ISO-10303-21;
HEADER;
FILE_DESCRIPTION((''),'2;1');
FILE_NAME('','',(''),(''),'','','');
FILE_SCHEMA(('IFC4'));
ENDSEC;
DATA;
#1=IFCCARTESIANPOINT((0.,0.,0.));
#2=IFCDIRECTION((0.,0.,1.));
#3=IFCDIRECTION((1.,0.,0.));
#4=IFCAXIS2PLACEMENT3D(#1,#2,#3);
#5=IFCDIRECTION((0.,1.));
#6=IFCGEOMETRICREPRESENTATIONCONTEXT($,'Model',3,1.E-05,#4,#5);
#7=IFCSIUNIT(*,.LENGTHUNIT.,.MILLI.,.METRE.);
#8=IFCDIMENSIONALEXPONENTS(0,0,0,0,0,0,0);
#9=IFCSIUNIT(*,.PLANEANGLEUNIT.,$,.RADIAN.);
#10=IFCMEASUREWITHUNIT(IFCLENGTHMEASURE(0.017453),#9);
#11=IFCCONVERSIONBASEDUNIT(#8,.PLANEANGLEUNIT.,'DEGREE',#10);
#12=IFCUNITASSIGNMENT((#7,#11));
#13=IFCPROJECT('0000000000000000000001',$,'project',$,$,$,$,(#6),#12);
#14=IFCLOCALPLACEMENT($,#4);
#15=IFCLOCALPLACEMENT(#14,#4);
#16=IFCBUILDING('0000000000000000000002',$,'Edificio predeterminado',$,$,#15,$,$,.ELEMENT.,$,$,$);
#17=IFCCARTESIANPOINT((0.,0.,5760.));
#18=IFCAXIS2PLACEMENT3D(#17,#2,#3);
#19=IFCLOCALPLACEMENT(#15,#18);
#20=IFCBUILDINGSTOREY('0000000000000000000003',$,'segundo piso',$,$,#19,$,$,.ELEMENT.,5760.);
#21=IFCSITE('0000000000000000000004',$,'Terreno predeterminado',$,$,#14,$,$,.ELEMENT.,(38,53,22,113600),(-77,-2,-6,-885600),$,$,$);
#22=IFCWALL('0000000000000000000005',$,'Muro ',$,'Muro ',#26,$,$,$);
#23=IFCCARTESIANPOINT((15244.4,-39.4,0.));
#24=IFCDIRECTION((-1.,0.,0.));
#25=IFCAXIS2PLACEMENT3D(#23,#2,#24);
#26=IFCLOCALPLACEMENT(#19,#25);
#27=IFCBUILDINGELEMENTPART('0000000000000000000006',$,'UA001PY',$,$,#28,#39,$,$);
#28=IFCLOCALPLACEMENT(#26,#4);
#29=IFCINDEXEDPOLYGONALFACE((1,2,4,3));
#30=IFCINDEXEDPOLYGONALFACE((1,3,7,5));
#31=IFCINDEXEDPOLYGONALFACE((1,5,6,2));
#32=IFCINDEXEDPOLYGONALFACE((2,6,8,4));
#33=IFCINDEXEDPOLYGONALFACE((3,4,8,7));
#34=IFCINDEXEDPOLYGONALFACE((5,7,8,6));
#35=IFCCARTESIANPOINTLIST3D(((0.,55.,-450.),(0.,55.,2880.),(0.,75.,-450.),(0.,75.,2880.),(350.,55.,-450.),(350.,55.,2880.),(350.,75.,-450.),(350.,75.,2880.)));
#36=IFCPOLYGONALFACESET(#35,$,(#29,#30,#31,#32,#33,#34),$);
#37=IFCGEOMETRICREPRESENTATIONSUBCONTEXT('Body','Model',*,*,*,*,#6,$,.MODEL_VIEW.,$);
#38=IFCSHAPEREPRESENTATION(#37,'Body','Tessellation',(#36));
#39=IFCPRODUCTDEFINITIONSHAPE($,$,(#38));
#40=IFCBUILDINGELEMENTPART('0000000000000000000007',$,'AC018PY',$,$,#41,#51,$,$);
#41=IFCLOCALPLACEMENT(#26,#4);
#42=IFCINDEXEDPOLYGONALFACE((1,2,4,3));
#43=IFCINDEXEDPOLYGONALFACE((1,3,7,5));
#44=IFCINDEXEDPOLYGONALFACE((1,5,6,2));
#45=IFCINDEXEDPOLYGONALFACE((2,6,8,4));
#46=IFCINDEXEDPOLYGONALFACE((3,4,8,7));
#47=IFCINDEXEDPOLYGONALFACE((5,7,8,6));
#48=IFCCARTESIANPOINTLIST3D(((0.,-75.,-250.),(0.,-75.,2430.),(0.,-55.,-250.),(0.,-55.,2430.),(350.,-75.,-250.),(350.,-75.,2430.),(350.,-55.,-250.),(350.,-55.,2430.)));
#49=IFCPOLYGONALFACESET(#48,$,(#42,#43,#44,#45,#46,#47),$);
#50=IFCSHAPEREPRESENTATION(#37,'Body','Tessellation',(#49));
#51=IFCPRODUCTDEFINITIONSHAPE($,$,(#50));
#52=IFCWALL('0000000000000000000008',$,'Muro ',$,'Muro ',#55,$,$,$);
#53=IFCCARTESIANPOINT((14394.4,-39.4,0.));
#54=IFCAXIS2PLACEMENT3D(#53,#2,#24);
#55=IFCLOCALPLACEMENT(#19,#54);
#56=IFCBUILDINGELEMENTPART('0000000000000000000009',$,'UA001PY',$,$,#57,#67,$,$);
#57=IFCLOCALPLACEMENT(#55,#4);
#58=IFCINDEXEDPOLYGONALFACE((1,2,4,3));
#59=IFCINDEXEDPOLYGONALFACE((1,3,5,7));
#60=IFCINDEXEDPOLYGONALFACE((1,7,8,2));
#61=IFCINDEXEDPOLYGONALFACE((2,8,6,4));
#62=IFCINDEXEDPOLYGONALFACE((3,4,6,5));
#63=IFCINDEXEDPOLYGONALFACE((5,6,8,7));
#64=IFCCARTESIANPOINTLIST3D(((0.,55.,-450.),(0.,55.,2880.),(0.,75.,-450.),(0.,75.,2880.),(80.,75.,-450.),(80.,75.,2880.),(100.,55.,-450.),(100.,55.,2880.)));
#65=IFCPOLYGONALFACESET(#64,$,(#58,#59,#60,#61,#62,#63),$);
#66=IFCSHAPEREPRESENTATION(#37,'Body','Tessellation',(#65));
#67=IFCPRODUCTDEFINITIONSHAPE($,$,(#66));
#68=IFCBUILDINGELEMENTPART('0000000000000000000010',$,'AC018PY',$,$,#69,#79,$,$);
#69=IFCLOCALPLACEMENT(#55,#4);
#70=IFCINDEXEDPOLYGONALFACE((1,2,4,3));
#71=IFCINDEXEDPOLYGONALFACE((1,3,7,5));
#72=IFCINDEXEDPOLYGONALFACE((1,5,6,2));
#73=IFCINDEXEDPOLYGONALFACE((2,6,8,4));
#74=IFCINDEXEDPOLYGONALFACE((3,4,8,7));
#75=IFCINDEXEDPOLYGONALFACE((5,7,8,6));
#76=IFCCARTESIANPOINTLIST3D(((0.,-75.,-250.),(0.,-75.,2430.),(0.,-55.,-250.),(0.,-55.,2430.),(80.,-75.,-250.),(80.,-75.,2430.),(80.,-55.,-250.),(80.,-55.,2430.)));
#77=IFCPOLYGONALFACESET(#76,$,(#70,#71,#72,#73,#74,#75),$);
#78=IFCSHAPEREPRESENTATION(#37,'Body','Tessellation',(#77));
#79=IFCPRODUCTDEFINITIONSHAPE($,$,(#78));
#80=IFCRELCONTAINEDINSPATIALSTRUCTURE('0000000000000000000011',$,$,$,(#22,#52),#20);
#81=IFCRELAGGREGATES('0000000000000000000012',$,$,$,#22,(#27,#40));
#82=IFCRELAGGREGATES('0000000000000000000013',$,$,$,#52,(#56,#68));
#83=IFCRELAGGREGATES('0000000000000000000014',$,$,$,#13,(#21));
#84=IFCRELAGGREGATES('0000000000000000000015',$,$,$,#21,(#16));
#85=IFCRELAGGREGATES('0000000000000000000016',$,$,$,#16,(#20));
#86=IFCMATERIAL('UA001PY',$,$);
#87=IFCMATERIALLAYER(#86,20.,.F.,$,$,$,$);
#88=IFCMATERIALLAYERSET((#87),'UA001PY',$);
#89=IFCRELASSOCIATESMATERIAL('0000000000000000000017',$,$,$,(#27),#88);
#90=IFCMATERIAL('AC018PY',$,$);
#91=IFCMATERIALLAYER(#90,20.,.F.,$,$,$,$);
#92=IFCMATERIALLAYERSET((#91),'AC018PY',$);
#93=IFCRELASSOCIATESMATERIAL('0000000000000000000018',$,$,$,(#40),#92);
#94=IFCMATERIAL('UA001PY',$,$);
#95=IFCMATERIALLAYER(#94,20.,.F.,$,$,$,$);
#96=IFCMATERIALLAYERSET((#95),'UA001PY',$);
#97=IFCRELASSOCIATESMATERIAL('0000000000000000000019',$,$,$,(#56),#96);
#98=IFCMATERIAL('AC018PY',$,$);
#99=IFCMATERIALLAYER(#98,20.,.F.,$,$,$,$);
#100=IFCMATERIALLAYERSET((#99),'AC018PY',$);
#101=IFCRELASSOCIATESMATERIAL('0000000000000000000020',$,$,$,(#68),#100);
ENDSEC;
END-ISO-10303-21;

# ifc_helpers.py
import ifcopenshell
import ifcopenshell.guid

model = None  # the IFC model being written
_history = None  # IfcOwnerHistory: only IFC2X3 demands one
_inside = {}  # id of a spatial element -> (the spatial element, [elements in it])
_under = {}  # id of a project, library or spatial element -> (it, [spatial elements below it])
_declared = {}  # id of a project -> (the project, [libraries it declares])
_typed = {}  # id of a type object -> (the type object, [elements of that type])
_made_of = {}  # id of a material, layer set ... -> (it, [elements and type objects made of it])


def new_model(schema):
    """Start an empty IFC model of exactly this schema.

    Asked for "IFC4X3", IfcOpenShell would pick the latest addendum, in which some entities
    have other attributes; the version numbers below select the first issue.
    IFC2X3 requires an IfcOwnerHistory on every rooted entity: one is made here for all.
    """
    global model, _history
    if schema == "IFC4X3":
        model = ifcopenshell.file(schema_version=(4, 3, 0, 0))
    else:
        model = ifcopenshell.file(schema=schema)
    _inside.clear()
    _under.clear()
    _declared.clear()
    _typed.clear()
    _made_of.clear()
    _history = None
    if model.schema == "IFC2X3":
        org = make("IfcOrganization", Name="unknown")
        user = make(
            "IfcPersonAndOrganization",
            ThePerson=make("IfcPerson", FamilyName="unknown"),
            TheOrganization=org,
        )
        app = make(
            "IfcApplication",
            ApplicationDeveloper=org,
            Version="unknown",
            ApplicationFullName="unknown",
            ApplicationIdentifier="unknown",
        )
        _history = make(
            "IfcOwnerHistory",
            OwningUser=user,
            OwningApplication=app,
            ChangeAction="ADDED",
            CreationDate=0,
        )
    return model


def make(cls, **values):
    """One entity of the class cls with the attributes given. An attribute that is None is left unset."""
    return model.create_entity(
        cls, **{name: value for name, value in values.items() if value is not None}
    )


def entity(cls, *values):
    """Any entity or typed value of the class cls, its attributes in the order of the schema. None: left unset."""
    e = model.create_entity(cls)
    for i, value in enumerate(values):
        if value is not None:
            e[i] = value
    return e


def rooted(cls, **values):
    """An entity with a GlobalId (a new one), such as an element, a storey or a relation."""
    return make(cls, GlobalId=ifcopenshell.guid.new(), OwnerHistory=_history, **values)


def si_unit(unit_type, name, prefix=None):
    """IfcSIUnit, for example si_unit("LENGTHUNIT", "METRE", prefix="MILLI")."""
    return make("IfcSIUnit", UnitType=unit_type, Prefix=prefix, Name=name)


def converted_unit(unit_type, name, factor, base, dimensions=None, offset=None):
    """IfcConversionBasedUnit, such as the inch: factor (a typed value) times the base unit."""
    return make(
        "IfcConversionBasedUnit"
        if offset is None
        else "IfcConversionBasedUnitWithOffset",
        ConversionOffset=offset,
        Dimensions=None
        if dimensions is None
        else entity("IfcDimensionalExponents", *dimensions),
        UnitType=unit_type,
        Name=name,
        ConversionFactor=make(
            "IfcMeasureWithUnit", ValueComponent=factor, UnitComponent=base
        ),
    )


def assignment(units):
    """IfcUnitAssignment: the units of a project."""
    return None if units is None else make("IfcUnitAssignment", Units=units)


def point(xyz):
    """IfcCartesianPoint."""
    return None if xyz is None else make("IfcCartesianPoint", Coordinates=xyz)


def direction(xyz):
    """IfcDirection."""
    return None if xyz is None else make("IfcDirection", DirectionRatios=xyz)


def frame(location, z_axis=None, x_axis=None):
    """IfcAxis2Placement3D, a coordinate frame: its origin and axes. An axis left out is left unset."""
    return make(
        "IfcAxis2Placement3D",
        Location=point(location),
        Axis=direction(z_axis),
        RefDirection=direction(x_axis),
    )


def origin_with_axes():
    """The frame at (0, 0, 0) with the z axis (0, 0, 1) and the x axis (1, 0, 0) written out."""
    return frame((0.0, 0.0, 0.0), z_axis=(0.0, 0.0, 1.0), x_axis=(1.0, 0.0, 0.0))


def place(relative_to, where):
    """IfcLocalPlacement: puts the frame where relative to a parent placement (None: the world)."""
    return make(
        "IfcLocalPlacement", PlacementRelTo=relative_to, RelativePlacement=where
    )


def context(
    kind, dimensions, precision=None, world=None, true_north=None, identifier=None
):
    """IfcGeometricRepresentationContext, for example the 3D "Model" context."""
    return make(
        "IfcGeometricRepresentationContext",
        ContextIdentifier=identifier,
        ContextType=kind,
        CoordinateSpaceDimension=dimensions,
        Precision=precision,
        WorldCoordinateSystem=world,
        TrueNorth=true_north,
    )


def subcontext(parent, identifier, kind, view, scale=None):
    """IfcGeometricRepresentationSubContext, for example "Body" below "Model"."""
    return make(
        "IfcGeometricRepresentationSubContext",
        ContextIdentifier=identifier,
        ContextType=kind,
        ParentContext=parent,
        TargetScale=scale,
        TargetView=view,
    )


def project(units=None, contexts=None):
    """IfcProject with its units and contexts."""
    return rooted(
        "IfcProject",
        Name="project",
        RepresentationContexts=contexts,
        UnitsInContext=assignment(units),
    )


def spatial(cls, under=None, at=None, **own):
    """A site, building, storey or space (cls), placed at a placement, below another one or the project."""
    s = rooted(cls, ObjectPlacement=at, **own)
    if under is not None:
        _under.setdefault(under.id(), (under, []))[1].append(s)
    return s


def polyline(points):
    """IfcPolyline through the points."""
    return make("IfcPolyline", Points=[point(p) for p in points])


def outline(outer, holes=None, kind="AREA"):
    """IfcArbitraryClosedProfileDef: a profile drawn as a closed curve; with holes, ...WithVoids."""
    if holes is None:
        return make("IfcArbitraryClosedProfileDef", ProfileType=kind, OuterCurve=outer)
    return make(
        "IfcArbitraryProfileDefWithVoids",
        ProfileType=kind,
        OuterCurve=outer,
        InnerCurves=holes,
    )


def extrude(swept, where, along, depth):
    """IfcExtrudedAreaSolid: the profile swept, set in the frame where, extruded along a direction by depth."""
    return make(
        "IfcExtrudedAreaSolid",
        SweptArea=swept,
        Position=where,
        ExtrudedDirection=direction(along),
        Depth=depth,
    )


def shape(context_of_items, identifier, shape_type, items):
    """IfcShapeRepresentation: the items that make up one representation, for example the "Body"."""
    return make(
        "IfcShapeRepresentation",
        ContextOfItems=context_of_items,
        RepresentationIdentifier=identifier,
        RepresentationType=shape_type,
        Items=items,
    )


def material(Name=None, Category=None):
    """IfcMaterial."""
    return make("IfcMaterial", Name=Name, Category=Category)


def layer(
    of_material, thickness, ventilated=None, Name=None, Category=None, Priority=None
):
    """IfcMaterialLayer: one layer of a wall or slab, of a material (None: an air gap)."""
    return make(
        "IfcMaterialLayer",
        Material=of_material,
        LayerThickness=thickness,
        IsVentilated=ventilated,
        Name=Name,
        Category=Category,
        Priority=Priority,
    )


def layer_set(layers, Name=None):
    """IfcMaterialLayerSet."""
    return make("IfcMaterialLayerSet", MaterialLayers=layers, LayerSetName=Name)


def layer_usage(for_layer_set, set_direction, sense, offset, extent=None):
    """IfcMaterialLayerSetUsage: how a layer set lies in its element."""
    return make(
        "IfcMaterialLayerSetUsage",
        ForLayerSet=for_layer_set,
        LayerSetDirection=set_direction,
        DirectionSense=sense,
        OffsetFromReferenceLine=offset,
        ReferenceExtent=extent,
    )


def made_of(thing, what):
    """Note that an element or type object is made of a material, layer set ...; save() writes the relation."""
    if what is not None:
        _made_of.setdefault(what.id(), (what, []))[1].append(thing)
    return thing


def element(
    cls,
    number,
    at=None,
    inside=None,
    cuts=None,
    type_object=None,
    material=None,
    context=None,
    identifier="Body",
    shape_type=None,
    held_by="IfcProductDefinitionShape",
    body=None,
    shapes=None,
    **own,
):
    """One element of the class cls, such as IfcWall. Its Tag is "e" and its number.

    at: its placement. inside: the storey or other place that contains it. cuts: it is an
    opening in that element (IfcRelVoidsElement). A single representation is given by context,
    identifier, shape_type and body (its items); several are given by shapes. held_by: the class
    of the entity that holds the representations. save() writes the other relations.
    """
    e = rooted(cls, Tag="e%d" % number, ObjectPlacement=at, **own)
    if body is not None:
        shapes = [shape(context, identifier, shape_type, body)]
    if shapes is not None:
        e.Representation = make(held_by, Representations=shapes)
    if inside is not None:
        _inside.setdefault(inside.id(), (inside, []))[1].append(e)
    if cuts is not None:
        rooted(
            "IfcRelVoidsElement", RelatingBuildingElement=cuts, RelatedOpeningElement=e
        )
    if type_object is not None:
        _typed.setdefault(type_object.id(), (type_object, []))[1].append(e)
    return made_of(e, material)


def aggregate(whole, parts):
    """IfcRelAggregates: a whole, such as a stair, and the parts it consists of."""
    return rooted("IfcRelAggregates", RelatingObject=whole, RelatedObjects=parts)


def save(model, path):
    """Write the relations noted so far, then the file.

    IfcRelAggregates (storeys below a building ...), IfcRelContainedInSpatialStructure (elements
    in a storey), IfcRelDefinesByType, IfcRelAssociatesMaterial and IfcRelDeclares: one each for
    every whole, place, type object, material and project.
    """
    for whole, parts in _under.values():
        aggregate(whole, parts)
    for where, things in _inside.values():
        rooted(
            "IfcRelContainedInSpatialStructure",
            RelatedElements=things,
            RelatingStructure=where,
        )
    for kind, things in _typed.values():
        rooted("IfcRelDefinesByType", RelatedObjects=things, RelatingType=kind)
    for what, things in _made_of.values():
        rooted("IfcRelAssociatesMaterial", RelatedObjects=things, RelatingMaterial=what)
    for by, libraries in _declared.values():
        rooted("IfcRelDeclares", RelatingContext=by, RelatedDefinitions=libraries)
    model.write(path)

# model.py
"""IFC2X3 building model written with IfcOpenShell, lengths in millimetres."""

from ifc_helpers import new_model, entity, si_unit, converted_unit, direction, frame, origin_with_axes, place, context, subcontext, project, spatial, polyline, outline, extrude, material, layer, layer_set, layer_usage, element, aggregate, save


model = new_model("IFC2X3")

# Units and contexts
model_context = context("Model", 3, precision=1e-05, world=origin_with_axes(), true_north=direction((0.0, 1.0)))
body_context = subcontext(model_context, "Body", "Model", "MODEL_VIEW")
ifc_project = project(units=[si_unit("LENGTHUNIT", "METRE", prefix="MILLI"), converted_unit("PLANEANGLEUNIT", "DEGREE", entity("IfcLengthMeasure", 0.017453), si_unit("PLANEANGLEUNIT", "RADIAN"), dimensions=[0, 0, 0, 0, 0, 0, 0])], contexts=[model_context])

# Site, building, storey
site_placement = place(None, origin_with_axes())
site = spatial("IfcSite", under=ifc_project, at=site_placement, Name="Terreno predeterminado", CompositionType="ELEMENT", RefLatitude=(38, 53, 22, 113600), RefLongitude=(-77, -2, -6, -885600))
building_placement = place(site_placement, origin_with_axes())
building = spatial("IfcBuilding", under=site, at=building_placement, Name="Edificio predeterminado", CompositionType="ELEMENT")
storey_placement = place(building_placement, frame((0.0, 0.0, 5760.0), z_axis=(0.0, 0.0, 1.0), x_axis=(1.0, 0.0, 0.0)))
storey = spatial("IfcBuildingStorey", under=building, at=storey_placement, Name="segundo piso", CompositionType="ELEMENT", Elevation=5760.0)

# Walls, building element parts
wall_1_placement = place(storey_placement, frame((15244.4, -39.4, 0.0), z_axis=(0.0, 0.0, 1.0), x_axis=(-1.0, 0.0, 0.0)))
wall_1 = element("IfcWall", 1, at=wall_1_placement, inside=storey, Name="Muro ", ObjectType="Muro ")
ifc_material_1 = material(Name="UA001PY")
ifc_layer_1 = layer(ifc_material_1, 20.0, ventilated=False)
ifc_layer_set_1 = layer_set([ifc_layer_1], Name="UA001PY")
ifc_layer_usage_1 = layer_usage(ifc_layer_set_1, "AXIS2", "NEGATIVE", -75.0)
building_element_part_1_placement = place(wall_1_placement, origin_with_axes())
building_element_part_1 = element("IfcBuildingElementPart", 2, at=building_element_part_1_placement, material=ifc_layer_usage_1, Name="UA001PY", context=body_context, shape_type="SweptSolid", body=[
    extrude(outline(polyline([(350.0, 75.0), (350.0, 55.0), (0.0, 55.0), (0.0, 75.0), (350.0, 75.0)])), frame((0.0, 0.0, -450.0), z_axis=(0.0, 0.0, 1.0), x_axis=(1.0, 0.0, 0.0)), (0.0, 0.0, 1.0), 3330.0),
])
ifc_material_2 = material(Name="AC018PY")
ifc_layer_2 = layer(ifc_material_2, 20.0, ventilated=False)
ifc_layer_set_2 = layer_set([ifc_layer_2], Name="AC018PY")
ifc_layer_usage_2 = layer_usage(ifc_layer_set_2, "AXIS2", "NEGATIVE", 55.0)
building_element_part_2_placement = place(wall_1_placement, origin_with_axes())
building_element_part_2 = element("IfcBuildingElementPart", 3, at=building_element_part_2_placement, material=ifc_layer_usage_2, Name="AC018PY", context=body_context, shape_type="SweptSolid", body=[
    extrude(outline(polyline([(350.0, -55.0), (350.0, -75.0), (0.0, -75.0), (0.0, -55.0), (350.0, -55.0)])), frame((0.0, 0.0, -250.0), z_axis=(0.0, 0.0, 1.0), x_axis=(1.0, 0.0, 0.0)), (0.0, 0.0, 1.0), 2680.0),
])
aggregate(wall_1, [building_element_part_1, building_element_part_2])
wall_2_placement = place(storey_placement, frame((14394.4, -39.4, 0.0), z_axis=(0.0, 0.0, 1.0), x_axis=(-1.0, 0.0, 0.0)))
wall_2 = element("IfcWall", 4, at=wall_2_placement, inside=storey, Name="Muro ", ObjectType="Muro ")
ifc_material_3 = material(Name="UA001PY")
ifc_layer_3 = layer(ifc_material_3, 20.0, ventilated=False)
ifc_layer_set_3 = layer_set([ifc_layer_3], Name="UA001PY")
ifc_layer_usage_3 = layer_usage(ifc_layer_set_3, "AXIS2", "NEGATIVE", -75.0)
building_element_part_3_placement = place(wall_2_placement, origin_with_axes())
building_element_part_3 = element("IfcBuildingElementPart", 5, at=building_element_part_3_placement, material=ifc_layer_usage_3, Name="UA001PY", context=body_context, shape_type="SweptSolid", body=[
    extrude(outline(polyline([(80.0, 75.0), (100.0, 55.0), (0.0, 55.0), (0.0, 75.0), (80.0, 75.0)])), frame((0.0, 0.0, -450.0), z_axis=(0.0, 0.0, 1.0), x_axis=(1.0, 0.0, 0.0)), (0.0, 0.0, 1.0), 3330.0),
])
ifc_material_4 = material(Name="AC018PY")
ifc_layer_4 = layer(ifc_material_4, 20.0, ventilated=False)
ifc_layer_set_4 = layer_set([ifc_layer_4], Name="AC018PY")
ifc_layer_usage_4 = layer_usage(ifc_layer_set_4, "AXIS2", "NEGATIVE", 55.0)
building_element_part_4_placement = place(wall_2_placement, origin_with_axes())
building_element_part_4 = element("IfcBuildingElementPart", 6, at=building_element_part_4_placement, material=ifc_layer_usage_4, Name="AC018PY", context=body_context, shape_type="SweptSolid", body=[
    extrude(outline(polyline([(80.0, -55.0), (80.0, -75.0), (0.0, -75.0), (0.0, -55.0), (80.0, -55.0)])), frame((0.0, 0.0, -250.0), z_axis=(0.0, 0.0, 1.0), x_axis=(1.0, 0.0, 0.0)), (0.0, 0.0, 1.0), 2680.0),
])
aggregate(wall_2, [building_element_part_3, building_element_part_4])

save(model, "model.ifc")
